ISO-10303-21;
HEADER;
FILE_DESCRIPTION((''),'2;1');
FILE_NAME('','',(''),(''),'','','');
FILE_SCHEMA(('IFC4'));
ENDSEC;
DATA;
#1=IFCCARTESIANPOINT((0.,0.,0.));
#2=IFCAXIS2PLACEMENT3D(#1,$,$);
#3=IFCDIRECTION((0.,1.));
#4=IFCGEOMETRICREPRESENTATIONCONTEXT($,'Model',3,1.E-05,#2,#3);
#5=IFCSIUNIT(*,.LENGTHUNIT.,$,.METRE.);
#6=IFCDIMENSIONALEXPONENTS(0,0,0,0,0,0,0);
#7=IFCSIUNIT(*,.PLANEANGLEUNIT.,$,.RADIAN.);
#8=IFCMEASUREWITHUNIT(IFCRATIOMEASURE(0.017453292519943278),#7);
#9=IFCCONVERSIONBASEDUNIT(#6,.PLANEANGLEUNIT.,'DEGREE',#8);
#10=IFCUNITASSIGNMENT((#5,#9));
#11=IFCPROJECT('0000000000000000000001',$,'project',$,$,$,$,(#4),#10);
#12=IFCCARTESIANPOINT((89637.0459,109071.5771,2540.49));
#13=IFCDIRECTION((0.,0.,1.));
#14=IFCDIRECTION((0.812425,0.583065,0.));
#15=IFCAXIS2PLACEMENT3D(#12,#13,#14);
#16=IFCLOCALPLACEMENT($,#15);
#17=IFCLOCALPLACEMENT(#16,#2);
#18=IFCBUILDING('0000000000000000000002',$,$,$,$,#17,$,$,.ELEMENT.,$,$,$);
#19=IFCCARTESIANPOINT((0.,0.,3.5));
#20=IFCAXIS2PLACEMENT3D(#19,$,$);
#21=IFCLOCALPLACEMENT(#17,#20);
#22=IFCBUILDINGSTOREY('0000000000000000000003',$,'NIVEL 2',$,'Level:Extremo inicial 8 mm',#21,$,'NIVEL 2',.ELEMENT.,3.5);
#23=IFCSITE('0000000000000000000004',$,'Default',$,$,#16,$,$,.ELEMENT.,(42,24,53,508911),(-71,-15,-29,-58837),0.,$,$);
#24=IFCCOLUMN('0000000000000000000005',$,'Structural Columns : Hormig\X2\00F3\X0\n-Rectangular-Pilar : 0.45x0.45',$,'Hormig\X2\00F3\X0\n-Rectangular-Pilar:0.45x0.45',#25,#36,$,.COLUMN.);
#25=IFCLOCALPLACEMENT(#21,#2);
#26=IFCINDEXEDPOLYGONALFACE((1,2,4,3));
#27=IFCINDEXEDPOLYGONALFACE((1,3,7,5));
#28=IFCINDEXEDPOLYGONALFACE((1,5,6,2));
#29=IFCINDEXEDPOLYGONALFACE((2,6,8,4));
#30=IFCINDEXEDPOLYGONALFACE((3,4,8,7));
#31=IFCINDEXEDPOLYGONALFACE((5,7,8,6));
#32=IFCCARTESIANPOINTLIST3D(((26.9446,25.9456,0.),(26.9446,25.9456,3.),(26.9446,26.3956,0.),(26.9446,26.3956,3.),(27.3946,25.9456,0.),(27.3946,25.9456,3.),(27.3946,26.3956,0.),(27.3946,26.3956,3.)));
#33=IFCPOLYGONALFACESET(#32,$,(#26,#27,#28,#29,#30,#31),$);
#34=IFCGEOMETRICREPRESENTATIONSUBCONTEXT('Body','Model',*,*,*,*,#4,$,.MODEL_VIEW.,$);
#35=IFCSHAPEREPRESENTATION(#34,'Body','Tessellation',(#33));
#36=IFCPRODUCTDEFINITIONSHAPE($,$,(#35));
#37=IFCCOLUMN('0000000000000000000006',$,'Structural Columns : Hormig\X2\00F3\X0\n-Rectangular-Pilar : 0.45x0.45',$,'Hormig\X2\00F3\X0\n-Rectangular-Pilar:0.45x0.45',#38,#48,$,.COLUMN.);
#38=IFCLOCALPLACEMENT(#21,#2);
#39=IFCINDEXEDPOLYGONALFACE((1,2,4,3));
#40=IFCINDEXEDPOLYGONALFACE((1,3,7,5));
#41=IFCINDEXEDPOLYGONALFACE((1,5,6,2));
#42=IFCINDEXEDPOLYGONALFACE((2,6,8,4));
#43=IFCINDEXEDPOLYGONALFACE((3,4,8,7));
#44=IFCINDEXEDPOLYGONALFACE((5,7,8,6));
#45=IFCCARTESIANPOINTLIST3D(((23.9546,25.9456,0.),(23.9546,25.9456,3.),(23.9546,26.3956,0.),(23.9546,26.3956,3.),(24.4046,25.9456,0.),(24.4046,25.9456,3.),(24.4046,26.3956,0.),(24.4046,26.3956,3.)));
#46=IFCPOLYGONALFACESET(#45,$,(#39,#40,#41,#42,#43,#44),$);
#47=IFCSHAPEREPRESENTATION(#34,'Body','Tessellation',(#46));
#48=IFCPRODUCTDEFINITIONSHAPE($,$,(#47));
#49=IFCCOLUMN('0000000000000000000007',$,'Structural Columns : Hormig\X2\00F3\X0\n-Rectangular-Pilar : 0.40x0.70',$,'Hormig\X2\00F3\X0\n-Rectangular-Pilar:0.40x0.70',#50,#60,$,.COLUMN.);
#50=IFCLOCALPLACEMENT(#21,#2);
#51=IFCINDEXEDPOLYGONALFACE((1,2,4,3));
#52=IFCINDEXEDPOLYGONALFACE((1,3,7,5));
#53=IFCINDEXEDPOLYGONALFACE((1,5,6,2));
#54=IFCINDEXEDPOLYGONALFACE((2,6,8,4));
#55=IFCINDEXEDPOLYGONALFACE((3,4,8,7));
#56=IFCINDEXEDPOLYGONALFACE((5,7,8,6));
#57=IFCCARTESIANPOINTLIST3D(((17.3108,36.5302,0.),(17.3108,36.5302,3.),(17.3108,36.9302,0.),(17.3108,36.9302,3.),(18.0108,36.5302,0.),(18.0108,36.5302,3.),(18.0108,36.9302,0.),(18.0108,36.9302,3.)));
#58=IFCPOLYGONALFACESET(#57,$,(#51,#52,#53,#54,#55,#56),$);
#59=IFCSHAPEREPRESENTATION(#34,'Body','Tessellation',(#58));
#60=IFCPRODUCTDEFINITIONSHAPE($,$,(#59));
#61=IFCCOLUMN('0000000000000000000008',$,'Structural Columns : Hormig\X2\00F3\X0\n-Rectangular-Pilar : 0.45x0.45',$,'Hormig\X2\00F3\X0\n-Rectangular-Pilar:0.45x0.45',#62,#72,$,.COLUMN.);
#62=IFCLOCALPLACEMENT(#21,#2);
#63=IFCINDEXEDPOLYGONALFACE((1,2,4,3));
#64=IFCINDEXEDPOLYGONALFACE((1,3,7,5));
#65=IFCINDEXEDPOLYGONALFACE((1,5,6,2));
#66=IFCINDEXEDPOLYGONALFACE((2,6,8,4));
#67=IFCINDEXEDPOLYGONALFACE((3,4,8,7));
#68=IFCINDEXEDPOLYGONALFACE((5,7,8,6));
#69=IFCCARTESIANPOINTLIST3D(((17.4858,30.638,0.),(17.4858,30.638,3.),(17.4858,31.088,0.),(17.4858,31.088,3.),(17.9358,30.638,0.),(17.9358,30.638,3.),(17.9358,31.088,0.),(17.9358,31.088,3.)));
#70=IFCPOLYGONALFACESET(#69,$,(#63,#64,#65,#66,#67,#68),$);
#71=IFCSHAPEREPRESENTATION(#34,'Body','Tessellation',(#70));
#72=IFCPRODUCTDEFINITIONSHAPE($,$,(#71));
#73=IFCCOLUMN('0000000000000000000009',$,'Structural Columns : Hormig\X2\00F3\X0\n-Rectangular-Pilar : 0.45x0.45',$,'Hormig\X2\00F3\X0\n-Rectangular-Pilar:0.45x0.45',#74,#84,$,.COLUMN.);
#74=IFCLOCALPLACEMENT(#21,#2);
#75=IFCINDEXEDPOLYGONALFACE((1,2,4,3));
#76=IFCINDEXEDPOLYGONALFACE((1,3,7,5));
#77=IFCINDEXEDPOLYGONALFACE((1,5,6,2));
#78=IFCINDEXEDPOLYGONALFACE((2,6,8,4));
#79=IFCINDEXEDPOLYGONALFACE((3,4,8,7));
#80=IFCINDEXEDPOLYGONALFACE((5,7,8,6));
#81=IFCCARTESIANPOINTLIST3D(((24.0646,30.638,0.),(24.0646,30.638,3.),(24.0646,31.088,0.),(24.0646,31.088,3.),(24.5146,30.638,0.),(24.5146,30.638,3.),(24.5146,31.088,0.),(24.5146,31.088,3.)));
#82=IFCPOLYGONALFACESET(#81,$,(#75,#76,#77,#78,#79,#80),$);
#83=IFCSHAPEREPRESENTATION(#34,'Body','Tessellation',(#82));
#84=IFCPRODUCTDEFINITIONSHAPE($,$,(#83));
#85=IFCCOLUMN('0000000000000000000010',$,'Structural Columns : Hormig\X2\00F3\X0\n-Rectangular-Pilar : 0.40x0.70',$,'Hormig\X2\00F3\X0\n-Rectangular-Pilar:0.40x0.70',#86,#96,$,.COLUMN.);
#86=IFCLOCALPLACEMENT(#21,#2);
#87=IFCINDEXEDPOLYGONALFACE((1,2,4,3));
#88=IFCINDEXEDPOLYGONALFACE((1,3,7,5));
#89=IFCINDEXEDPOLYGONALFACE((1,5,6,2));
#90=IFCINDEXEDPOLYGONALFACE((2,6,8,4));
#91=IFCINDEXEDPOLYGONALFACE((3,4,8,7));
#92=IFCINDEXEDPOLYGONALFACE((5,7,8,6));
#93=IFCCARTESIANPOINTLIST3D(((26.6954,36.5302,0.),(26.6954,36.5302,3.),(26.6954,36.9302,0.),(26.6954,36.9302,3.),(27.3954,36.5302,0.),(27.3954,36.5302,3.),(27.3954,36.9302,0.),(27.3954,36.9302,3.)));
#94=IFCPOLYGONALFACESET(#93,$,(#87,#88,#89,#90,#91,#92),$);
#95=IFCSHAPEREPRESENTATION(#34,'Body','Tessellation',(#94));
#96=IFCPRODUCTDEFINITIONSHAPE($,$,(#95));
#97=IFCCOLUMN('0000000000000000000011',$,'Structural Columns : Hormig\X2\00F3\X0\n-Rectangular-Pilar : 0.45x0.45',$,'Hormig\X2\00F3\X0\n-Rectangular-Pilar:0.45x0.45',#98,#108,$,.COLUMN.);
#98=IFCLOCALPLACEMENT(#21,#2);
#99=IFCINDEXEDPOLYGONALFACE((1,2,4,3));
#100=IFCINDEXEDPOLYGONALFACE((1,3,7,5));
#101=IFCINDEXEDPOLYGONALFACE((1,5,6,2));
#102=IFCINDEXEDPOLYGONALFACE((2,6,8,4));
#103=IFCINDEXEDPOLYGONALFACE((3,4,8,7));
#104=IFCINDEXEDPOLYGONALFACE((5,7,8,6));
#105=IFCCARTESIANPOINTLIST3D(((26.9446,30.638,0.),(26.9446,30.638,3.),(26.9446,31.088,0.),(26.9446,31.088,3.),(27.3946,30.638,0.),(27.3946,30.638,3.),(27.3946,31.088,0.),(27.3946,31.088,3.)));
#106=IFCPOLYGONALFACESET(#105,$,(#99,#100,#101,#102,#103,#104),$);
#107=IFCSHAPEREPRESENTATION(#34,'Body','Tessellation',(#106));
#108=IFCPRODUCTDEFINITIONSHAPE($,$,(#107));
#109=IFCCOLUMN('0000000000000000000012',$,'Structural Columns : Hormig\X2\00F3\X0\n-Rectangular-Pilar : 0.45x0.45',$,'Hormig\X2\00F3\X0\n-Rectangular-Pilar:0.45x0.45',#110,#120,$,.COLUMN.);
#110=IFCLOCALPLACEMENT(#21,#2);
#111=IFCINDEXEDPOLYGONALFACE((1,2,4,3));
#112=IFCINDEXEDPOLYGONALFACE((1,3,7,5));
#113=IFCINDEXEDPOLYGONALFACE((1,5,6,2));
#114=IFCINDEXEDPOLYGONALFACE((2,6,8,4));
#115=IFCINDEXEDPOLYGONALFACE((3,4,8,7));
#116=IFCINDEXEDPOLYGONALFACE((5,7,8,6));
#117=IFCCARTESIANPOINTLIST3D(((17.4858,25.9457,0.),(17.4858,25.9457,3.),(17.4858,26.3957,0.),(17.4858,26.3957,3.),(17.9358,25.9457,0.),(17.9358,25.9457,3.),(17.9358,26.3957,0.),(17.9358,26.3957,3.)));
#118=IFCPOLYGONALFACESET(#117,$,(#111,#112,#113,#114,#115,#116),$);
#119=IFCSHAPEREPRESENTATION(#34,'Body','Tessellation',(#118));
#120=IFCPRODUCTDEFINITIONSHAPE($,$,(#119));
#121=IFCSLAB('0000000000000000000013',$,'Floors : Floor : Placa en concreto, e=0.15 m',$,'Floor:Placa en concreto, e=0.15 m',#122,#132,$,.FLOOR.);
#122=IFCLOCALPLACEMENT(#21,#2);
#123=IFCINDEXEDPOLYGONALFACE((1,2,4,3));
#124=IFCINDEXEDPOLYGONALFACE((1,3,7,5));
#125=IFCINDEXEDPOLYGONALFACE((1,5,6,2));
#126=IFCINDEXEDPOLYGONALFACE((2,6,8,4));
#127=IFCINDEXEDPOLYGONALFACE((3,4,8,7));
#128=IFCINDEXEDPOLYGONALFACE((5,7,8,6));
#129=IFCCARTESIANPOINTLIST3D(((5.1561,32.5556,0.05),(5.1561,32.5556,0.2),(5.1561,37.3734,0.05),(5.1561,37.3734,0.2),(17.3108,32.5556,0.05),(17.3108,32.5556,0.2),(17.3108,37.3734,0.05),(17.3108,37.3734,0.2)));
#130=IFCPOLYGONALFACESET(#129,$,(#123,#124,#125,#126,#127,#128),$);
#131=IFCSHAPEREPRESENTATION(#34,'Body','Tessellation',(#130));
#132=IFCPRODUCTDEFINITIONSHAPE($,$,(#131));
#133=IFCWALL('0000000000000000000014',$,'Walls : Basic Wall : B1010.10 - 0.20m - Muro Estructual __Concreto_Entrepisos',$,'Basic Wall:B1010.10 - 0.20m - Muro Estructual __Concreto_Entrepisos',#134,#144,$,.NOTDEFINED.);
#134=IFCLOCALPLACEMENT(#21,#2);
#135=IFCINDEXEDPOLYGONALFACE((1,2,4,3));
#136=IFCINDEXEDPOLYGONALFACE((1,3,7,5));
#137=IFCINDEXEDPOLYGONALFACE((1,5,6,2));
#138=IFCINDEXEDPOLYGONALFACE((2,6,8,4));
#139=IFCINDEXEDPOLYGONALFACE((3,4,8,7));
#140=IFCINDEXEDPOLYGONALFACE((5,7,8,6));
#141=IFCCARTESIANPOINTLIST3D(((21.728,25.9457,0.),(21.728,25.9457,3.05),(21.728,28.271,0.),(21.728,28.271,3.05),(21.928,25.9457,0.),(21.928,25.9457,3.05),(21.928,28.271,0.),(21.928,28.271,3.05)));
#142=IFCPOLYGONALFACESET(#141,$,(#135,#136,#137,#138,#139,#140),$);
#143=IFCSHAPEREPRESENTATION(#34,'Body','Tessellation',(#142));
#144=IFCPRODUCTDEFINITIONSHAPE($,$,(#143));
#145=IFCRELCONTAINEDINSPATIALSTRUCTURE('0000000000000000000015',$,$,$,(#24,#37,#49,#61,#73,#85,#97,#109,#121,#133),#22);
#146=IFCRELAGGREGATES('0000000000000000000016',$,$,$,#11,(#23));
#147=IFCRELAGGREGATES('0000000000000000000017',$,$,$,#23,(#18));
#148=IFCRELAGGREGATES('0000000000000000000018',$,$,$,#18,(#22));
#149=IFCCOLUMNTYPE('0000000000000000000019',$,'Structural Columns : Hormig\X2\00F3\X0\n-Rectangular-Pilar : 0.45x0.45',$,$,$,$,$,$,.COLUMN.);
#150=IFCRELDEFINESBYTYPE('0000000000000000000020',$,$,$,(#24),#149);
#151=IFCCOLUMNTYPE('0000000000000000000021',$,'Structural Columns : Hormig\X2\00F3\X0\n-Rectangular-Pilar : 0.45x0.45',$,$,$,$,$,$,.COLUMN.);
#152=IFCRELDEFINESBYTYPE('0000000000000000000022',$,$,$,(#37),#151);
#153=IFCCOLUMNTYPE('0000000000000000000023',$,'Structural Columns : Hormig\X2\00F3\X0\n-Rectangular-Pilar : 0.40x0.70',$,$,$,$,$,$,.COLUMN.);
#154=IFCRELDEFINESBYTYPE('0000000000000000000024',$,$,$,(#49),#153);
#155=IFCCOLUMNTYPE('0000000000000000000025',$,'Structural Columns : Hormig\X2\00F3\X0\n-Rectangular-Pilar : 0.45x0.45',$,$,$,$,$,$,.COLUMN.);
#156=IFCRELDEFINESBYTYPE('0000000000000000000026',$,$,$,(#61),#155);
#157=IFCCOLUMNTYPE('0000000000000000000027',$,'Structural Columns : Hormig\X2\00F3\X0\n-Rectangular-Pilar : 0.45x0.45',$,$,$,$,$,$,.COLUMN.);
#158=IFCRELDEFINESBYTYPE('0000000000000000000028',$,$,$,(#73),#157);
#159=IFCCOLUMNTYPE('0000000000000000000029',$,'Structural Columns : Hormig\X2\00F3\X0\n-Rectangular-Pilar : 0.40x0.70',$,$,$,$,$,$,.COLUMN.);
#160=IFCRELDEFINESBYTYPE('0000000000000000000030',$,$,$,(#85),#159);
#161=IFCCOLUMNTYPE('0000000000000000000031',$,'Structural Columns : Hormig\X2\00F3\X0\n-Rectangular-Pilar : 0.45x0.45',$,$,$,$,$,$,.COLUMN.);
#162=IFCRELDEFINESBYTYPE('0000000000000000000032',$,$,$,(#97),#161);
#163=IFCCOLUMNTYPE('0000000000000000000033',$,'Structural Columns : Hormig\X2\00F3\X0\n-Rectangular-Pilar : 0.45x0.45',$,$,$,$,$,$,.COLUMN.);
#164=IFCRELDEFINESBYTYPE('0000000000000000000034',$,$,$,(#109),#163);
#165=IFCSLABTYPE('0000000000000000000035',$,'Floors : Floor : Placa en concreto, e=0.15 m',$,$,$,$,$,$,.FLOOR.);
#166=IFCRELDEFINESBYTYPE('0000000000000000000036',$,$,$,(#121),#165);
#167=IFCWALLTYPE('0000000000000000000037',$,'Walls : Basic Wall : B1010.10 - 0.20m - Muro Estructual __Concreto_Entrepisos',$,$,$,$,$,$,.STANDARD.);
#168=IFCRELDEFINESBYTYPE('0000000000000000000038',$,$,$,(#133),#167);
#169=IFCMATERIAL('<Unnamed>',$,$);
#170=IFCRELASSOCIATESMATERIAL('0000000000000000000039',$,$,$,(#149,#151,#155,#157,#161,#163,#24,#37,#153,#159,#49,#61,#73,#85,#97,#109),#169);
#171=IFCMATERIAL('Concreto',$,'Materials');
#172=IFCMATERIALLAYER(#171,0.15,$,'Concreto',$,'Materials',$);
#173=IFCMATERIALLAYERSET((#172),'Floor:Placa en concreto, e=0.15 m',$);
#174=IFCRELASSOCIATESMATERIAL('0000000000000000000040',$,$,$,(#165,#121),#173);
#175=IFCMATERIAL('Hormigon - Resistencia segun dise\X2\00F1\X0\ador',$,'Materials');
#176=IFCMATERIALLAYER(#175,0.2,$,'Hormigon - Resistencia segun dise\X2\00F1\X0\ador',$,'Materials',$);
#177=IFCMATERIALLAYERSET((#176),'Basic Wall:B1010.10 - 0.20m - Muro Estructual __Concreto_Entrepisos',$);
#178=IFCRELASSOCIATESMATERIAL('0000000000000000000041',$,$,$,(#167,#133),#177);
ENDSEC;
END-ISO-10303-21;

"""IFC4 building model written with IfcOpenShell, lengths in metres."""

from ifc_helpers import new_model, entity, si_unit, converted_unit, direction, frame, frame_2d, origin, origin_2d_with_axis, place, context, subcontext, project, spatial, polyline, segment, composite_curve, rectangle, outline, extrude, source, transform, mapped, material, layer, layer_set, layer_usage, material_profile, profile_set, profile_usage, type_object, type_shapes, element, save


model = new_model("IFC4")

# Units and contexts
model_context = context("Model", 3, precision=1e-05, world=origin(), true_north=direction((0.0, 1.0)))
body_context = subcontext(model_context, "Body", "Model", "MODEL_VIEW")
ifc_project = project(units=[si_unit("LENGTHUNIT", "METRE"), converted_unit("PLANEANGLEUNIT", "DEGREE", entity("IfcRatioMeasure", 0.017453292519943278), si_unit("PLANEANGLEUNIT", "RADIAN"), dimensions=[0, 0, 0, 0, 0, 0, 0])], contexts=[model_context])

# Site, building, storey
site_placement = place(None, frame((89637.0459, 109071.5771, 2540.49), z_axis=(0.0, 0.0, 1.0), x_axis=(0.812425, 0.583065, 0.0)))
site = spatial("IfcSite", under=ifc_project, at=site_placement, Name="Default", CompositionType="ELEMENT", RefLatitude=(42, 24, 53, 508911), RefLongitude=(-71, -15, -29, -58837), RefElevation=0.0)
building_placement = place(site_placement, origin())
building = spatial("IfcBuilding", under=site, at=building_placement, CompositionType="ELEMENT")
storey_placement = place(building_placement, frame((0.0, 0.0, 3.5)))
storey = spatial("IfcBuildingStorey", under=building, at=storey_placement, Name="NIVEL 2", ObjectType="Level:Extremo inicial 8 mm", LongName="NIVEL 2", CompositionType="ELEMENT", Elevation=3.5)

# Columns
ifc_material_1 = material(Name="<Unnamed>")
ifc_material_profile_1 = material_profile(ifc_material_1, outline(composite_curve([segment(polyline([(0.225, 0.225, 0.0), (0.225, -0.225, 0.0)]), True, "CONTINUOUS"), segment(polyline([(0.225, -0.225, 0.0), (-0.225, -0.225, 0.0)]), True, "CONTINUOUS"), segment(polyline([(-0.225, -0.225, 0.0), (-0.225, 0.225, 0.0)]), True, "CONTINUOUS"), segment(polyline([(-0.225, 0.225, 0.0), (0.225, 0.225, 0.0)]), True, "CONTINUOUS")], self_intersect=False), kind="CURVE"), Name="0.45x0.45")
ifc_material_profile_2 = material_profile(ifc_material_1, outline(composite_curve([segment(polyline([(0.225, 0.225, 6.5), (-0.225, 0.225, 6.5)]), True, "CONTINUOUS"), segment(polyline([(-0.225, 0.225, 6.5), (-0.225, -0.225, 6.5)]), True, "CONTINUOUS"), segment(polyline([(-0.225, -0.225, 6.5), (0.225, -0.225, 6.5)]), True, "CONTINUOUS"), segment(polyline([(0.225, -0.225, 6.5), (0.225, 0.225, 6.5)]), True, "CONTINUOUS")], self_intersect=False), kind="CURVE"), Name="0.45x0.45")
ifc_profile_set_1 = profile_set([ifc_material_profile_1, ifc_material_profile_2], Name="0.45x0.45")
ifc_profile_usage_1 = profile_usage(ifc_profile_set_1)
column_type_1 = type_object("IfcColumnType", Name="Structural Columns : Hormigón-Rectangular-Pilar : 0.45x0.45", PredefinedType="COLUMN", material=ifc_profile_set_1)
shared_shape_1 = source(origin(), body_context, "Body", "SweptSolid", [
    extrude(rectangle(XDim=0.45, YDim=0.45, at=origin_2d_with_axis()), frame((27.1696, 26.1706, 3.5), z_axis=(0.0, 0.0, 1.0), x_axis=(0.0, -1.0, 0.0)), (0.0, 0.0, 1.0), 3.0),
])
type_shapes(column_type_1, [shared_shape_1])
column_1_placement = place(storey_placement, frame((0.0, 0.0, -3.5)))
element("IfcColumn", 1, at=column_1_placement, inside=storey, type_object=column_type_1, material=ifc_profile_usage_1, Name="Structural Columns : Hormigón-Rectangular-Pilar : 0.45x0.45", ObjectType="Hormigón-Rectangular-Pilar:0.45x0.45", PredefinedType="COLUMN", context=body_context, shape_type="MappedRepresentation", body=[
    mapped(shared_shape_1, transform((0.0, 0.0, 0.0), scale=1.0)),
])
ifc_profile_usage_2 = profile_usage(ifc_profile_set_1)
column_type_2 = type_object("IfcColumnType", Name="Structural Columns : Hormigón-Rectangular-Pilar : 0.45x0.45", PredefinedType="COLUMN", material=ifc_profile_set_1)
shared_shape_2 = source(origin(), body_context, "Body", "SweptSolid", [
    extrude(rectangle(XDim=0.45, YDim=0.45, at=origin_2d_with_axis()), frame((24.1796, 26.1706, 3.5), z_axis=(0.0, 0.0, 1.0), x_axis=(0.0, -1.0, 0.0)), (0.0, 0.0, 1.0), 3.0),
])
type_shapes(column_type_2, [shared_shape_2])
column_2_placement = place(storey_placement, frame((0.0, 0.0, -3.5)))
element("IfcColumn", 2, at=column_2_placement, inside=storey, type_object=column_type_2, material=ifc_profile_usage_2, Name="Structural Columns : Hormigón-Rectangular-Pilar : 0.45x0.45", ObjectType="Hormigón-Rectangular-Pilar:0.45x0.45", PredefinedType="COLUMN", context=body_context, shape_type="MappedRepresentation", body=[
    mapped(shared_shape_2, transform((0.0, 0.0, 0.0), scale=1.0)),
])
ifc_material_profile_3 = material_profile(ifc_material_1, outline(composite_curve([segment(polyline([(0.2, 0.35, 0.0), (0.2, -0.35, 0.0)]), True, "CONTINUOUS"), segment(polyline([(0.2, -0.35, 0.0), (-0.2, -0.35, 0.0)]), True, "CONTINUOUS"), segment(polyline([(-0.2, -0.35, 0.0), (-0.2, 0.35, 0.0)]), True, "CONTINUOUS"), segment(polyline([(-0.2, 0.35, 0.0), (0.2, 0.35, 0.0)]), True, "CONTINUOUS")], self_intersect=False), kind="CURVE"), Name="0.40x0.70")
ifc_material_profile_4 = material_profile(ifc_material_1, outline(composite_curve([segment(polyline([(0.2, 0.35, 6.5), (-0.2, 0.35, 6.5)]), True, "CONTINUOUS"), segment(polyline([(-0.2, 0.35, 6.5), (-0.2, -0.35, 6.5)]), True, "CONTINUOUS"), segment(polyline([(-0.2, -0.35, 6.5), (0.2, -0.35, 6.5)]), True, "CONTINUOUS"), segment(polyline([(0.2, -0.35, 6.5), (0.2, 0.35, 6.5)]), True, "CONTINUOUS")], self_intersect=False), kind="CURVE"), Name="0.40x0.70")
ifc_profile_set_2 = profile_set([ifc_material_profile_3, ifc_material_profile_4], Name="0.40x0.70")
ifc_profile_usage_3 = profile_usage(ifc_profile_set_2)
column_type_3 = type_object("IfcColumnType", Name="Structural Columns : Hormigón-Rectangular-Pilar : 0.40x0.70", PredefinedType="COLUMN", material=ifc_profile_set_2)
shared_shape_3 = source(origin(), body_context, "Body", "SweptSolid", [
    extrude(rectangle(XDim=0.4, YDim=0.7, at=frame_2d((0.0, 0.0), x_axis=(1.0, 0.0))), frame((17.6608, 36.7302, 3.5), z_axis=(0.0, 0.0, 1.0), x_axis=(0.0, -1.0, 0.0)), (0.0, 0.0, 1.0), 3.0),
])
type_shapes(column_type_3, [shared_shape_3])
column_3_placement = place(storey_placement, frame((0.0, 0.0, -3.5)))
element("IfcColumn", 3, at=column_3_placement, inside=storey, type_object=column_type_3, material=ifc_profile_usage_3, Name="Structural Columns : Hormigón-Rectangular-Pilar : 0.40x0.70", ObjectType="Hormigón-Rectangular-Pilar:0.40x0.70", PredefinedType="COLUMN", context=body_context, shape_type="MappedRepresentation", body=[
    mapped(shared_shape_3, transform((0.0, 0.0, 0.0), scale=1.0)),
])
ifc_profile_usage_4 = profile_usage(ifc_profile_set_1)
column_type_4 = type_object("IfcColumnType", Name="Structural Columns : Hormigón-Rectangular-Pilar : 0.45x0.45", PredefinedType="COLUMN", material=ifc_profile_set_1)
shared_shape_4 = source(origin(), body_context, "Body", "SweptSolid", [
    extrude(rectangle(XDim=0.45, YDim=0.45, at=origin_2d_with_axis()), frame((17.7108, 30.863, 3.5), z_axis=(0.0, 0.0, 1.0), x_axis=(0.0, -1.0, 0.0)), (0.0, 0.0, 1.0), 3.0),
])
type_shapes(column_type_4, [shared_shape_4])
column_4_placement = place(storey_placement, frame((0.0, 0.0, -3.5)))
element("IfcColumn", 4, at=column_4_placement, inside=storey, type_object=column_type_4, material=ifc_profile_usage_4, Name="Structural Columns : Hormigón-Rectangular-Pilar : 0.45x0.45", ObjectType="Hormigón-Rectangular-Pilar:0.45x0.45", PredefinedType="COLUMN", context=body_context, shape_type="MappedRepresentation", body=[
    mapped(shared_shape_4, transform((0.0, 0.0, 0.0), scale=1.0)),
])
ifc_profile_usage_5 = profile_usage(ifc_profile_set_1)
column_type_5 = type_object("IfcColumnType", Name="Structural Columns : Hormigón-Rectangular-Pilar : 0.45x0.45", PredefinedType="COLUMN", material=ifc_profile_set_1)
shared_shape_5 = source(origin(), body_context, "Body", "SweptSolid", [
    extrude(rectangle(XDim=0.45, YDim=0.45, at=origin_2d_with_axis()), frame((24.2896, 30.863, 3.5), z_axis=(0.0, 0.0, 1.0), x_axis=(0.0, -1.0, 0.0)), (0.0, 0.0, 1.0), 3.0),
])
type_shapes(column_type_5, [shared_shape_5])
column_5_placement = place(storey_placement, frame((0.0, 0.0, -3.5)))
element("IfcColumn", 5, at=column_5_placement, inside=storey, type_object=column_type_5, material=ifc_profile_usage_5, Name="Structural Columns : Hormigón-Rectangular-Pilar : 0.45x0.45", ObjectType="Hormigón-Rectangular-Pilar:0.45x0.45", PredefinedType="COLUMN", context=body_context, shape_type="MappedRepresentation", body=[
    mapped(shared_shape_5, transform((0.0, 0.0, 0.0), scale=1.0)),
])
ifc_profile_usage_6 = profile_usage(ifc_profile_set_2)
column_type_6 = type_object("IfcColumnType", Name="Structural Columns : Hormigón-Rectangular-Pilar : 0.40x0.70", PredefinedType="COLUMN", material=ifc_profile_set_2)
shared_shape_6 = source(origin(), body_context, "Body", "SweptSolid", [
    extrude(rectangle(XDim=0.4, YDim=0.7, at=frame_2d((0.0, 0.0), x_axis=(1.0, 0.0))), frame((27.0454, 36.7302, 3.5), z_axis=(0.0, 0.0, 1.0), x_axis=(0.0, -1.0, 0.0)), (0.0, 0.0, 1.0), 3.0),
])
type_shapes(column_type_6, [shared_shape_6])
column_6_placement = place(storey_placement, frame((0.0, 0.0, -3.5)))
element("IfcColumn", 6, at=column_6_placement, inside=storey, type_object=column_type_6, material=ifc_profile_usage_6, Name="Structural Columns : Hormigón-Rectangular-Pilar : 0.40x0.70", ObjectType="Hormigón-Rectangular-Pilar:0.40x0.70", PredefinedType="COLUMN", context=body_context, shape_type="MappedRepresentation", body=[
    mapped(shared_shape_6, transform((0.0, 0.0, 0.0), scale=1.0)),
])
ifc_profile_usage_7 = profile_usage(ifc_profile_set_1)
column_type_7 = type_object("IfcColumnType", Name="Structural Columns : Hormigón-Rectangular-Pilar : 0.45x0.45", PredefinedType="COLUMN", material=ifc_profile_set_1)
shared_shape_7 = source(origin(), body_context, "Body", "SweptSolid", [
    extrude(rectangle(XDim=0.45, YDim=0.45, at=origin_2d_with_axis()), frame((27.1696, 30.863, 3.5), z_axis=(0.0, 0.0, 1.0), x_axis=(0.0, -1.0, 0.0)), (0.0, 0.0, 1.0), 3.0),
])
type_shapes(column_type_7, [shared_shape_7])
column_7_placement = place(storey_placement, frame((0.0, 0.0, -3.5)))
element("IfcColumn", 7, at=column_7_placement, inside=storey, type_object=column_type_7, material=ifc_profile_usage_7, Name="Structural Columns : Hormigón-Rectangular-Pilar : 0.45x0.45", ObjectType="Hormigón-Rectangular-Pilar:0.45x0.45", PredefinedType="COLUMN", context=body_context, shape_type="MappedRepresentation", body=[
    mapped(shared_shape_7, transform((0.0, 0.0, 0.0), scale=1.0)),
])
ifc_profile_usage_8 = profile_usage(ifc_profile_set_1)
column_type_8 = type_object("IfcColumnType", Name="Structural Columns : Hormigón-Rectangular-Pilar : 0.45x0.45", PredefinedType="COLUMN", material=ifc_profile_set_1)
shared_shape_8 = source(origin(), body_context, "Body", "SweptSolid", [
    extrude(rectangle(XDim=0.45, YDim=0.45, at=origin_2d_with_axis()), frame((17.7108, 26.1707, 3.5), z_axis=(0.0, 0.0, 1.0), x_axis=(0.0, -1.0, 0.0)), (0.0, 0.0, 1.0), 3.0),
])
type_shapes(column_type_8, [shared_shape_8])
column_8_placement = place(storey_placement, frame((0.0, 0.0, -3.5)))
element("IfcColumn", 8, at=column_8_placement, inside=storey, type_object=column_type_8, material=ifc_profile_usage_8, Name="Structural Columns : Hormigón-Rectangular-Pilar : 0.45x0.45", ObjectType="Hormigón-Rectangular-Pilar:0.45x0.45", PredefinedType="COLUMN", context=body_context, shape_type="MappedRepresentation", body=[
    mapped(shared_shape_8, transform((0.0, 0.0, 0.0), scale=1.0)),
])

# Shared definitions
ifc_material_2 = material(Name="Hormigon - Resistencia segun diseñador", Category="Materials")

# Slab
ifc_material_3 = material(Name="Concreto", Category="Materials")
ifc_layer_1 = layer(ifc_material_3, 0.15, Name="Concreto", Category="Materials")
ifc_layer_set_1 = layer_set([ifc_layer_1], Name="Floor:Placa en concreto, e=0.15 m")
ifc_layer_usage_1 = layer_usage(ifc_layer_set_1, "AXIS3", "POSITIVE", 0.0)
slab_type_1 = type_object("IfcSlabType", Name="Floors : Floor : Placa en concreto, e=0.15 m", PredefinedType="FLOOR", material=ifc_layer_set_1)
slab_1_placement = place(storey_placement, origin())
element("IfcSlab", 9, at=slab_1_placement, inside=storey, type_object=slab_type_1, material=ifc_layer_usage_1, Name="Floors : Floor : Placa en concreto, e=0.15 m", ObjectType="Floor:Placa en concreto, e=0.15 m", PredefinedType="FLOOR", context=body_context, shape_type="SweptSolid", body=[
    extrude(rectangle(XDim=4.8179, YDim=12.1548, at=frame_2d((0.0, 0.0), x_axis=(1.0, 0.0))), frame((11.2335, 34.9645, 0.2), z_axis=(0.0, 0.0, -1.0), x_axis=(0.0, 1.0, 0.0)), (0.0, 0.0, 1.0), 0.15),
])

# Wall
ifc_layer_2 = layer(ifc_material_2, 0.2, Name="Hormigon - Resistencia segun diseñador", Category="Materials")
ifc_layer_set_2 = layer_set([ifc_layer_2], Name="Basic Wall:B1010.10 - 0.20m - Muro Estructual __Concreto_Entrepisos")
ifc_layer_usage_2 = layer_usage(ifc_layer_set_2, "AXIS2", "NEGATIVE", 0.1)
wall_type = type_object("IfcWallType", Name="Walls : Basic Wall : B1010.10 - 0.20m - Muro Estructual __Concreto_Entrepisos", PredefinedType="STANDARD", material=ifc_layer_set_2)
wall_1_placement = place(storey_placement, frame((21.828, 25.9457, 0.0), z_axis=(0.0, 0.0, 1.0), x_axis=(0.0, 1.0, 0.0)))
element("IfcWall", 10, at=wall_1_placement, inside=storey, type_object=wall_type, material=ifc_layer_usage_2, Name="Walls : Basic Wall : B1010.10 - 0.20m - Muro Estructual __Concreto_Entrepisos", ObjectType="Basic Wall:B1010.10 - 0.20m - Muro Estructual __Concreto_Entrepisos", PredefinedType="NOTDEFINED", context=body_context, shape_type="SweptSolid", body=[
    extrude(rectangle(XDim=2.3253, YDim=0.2, at=frame_2d((1.1626, 0.0), x_axis=(-1.0, 0.0))), origin(), (0.0, 0.0, 1.0), 3.05),
])

save(model, "model.ifc")
